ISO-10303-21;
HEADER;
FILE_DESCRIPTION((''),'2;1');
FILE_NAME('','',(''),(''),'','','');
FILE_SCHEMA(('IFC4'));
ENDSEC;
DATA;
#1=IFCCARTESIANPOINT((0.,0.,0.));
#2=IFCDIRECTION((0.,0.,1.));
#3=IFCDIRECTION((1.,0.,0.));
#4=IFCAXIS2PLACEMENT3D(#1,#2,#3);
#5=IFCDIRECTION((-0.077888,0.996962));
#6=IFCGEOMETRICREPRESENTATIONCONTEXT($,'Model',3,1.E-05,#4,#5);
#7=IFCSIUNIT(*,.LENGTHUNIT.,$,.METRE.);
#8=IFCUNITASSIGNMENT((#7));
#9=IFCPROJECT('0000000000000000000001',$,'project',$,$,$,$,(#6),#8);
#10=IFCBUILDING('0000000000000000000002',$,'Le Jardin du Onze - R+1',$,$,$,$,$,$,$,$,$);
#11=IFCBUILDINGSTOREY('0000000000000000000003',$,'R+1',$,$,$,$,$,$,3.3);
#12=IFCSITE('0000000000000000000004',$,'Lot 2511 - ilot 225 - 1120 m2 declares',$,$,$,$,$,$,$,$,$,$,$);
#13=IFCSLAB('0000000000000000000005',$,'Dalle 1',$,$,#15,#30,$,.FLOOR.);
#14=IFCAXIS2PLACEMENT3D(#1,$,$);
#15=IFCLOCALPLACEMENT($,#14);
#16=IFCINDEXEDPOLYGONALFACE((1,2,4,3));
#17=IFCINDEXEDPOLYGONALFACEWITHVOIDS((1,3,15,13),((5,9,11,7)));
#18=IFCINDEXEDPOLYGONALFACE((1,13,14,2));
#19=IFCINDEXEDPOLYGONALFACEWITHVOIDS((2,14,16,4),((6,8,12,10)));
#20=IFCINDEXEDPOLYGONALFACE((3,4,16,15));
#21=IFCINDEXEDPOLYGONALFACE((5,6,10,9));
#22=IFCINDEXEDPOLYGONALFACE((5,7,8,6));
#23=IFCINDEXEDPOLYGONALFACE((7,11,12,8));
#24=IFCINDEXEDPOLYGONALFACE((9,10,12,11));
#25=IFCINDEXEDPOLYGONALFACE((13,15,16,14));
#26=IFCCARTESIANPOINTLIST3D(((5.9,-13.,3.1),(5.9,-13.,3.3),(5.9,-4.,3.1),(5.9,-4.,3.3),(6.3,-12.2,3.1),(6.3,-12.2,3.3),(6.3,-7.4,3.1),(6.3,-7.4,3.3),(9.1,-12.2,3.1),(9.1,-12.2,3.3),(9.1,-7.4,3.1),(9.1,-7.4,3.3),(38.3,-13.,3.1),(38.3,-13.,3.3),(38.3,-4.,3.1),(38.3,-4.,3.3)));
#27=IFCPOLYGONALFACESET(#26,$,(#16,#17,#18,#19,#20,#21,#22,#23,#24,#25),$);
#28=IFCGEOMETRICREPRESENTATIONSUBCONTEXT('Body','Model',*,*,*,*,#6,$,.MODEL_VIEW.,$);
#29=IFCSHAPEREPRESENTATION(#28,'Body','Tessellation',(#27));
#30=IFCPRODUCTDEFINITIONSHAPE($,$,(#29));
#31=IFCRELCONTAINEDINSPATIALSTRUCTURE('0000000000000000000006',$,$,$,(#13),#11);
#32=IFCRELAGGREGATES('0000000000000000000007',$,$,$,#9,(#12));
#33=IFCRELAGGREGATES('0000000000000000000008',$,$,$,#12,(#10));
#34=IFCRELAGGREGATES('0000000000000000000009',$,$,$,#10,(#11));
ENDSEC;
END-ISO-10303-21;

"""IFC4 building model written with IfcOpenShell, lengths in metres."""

from ifc_helpers import new_model, si_unit, direction, frame, origin_with_axes, place, context, subcontext, project, spatial, polyline, outline, extrude, element, save


model = new_model("IFC4")

# Units and contexts
model_context = context("Model", 3, precision=1e-05, world=origin_with_axes(), true_north=direction((-0.077888, 0.996962)))
body_context = subcontext(model_context, "Body", "Model", "MODEL_VIEW")
ifc_project = project(units=[si_unit("LENGTHUNIT", "METRE")], contexts=[model_context])

# Site, building, storey
site = spatial("IfcSite", under=ifc_project, Name="Lot 2511 - ilot 225 - 1120 m2 declares")
building = spatial("IfcBuilding", under=site, Name="Le Jardin du Onze - R+1")
storey = spatial("IfcBuildingStorey", under=building, Name="R+1", Elevation=3.3)

# Slab, opening
slab_placement = place(None, origin_with_axes())
slab = element("IfcSlab", 1, at=slab_placement, inside=storey, Name="Dalle 1", PredefinedType="FLOOR", context=body_context, shape_type="SweptSolid", body=[
    extrude(outline(polyline([(38.3, -13.0), (38.3, -4.0), (5.9, -4.0), (5.9, -13.0), (38.3, -13.0)])), frame((0.0, 0.0, 3.1)), (0.0, 0.0, 1.0), 0.2),
])
opening_1_placement = place(None, origin_with_axes())
element("IfcOpeningElement", 2, at=opening_1_placement, cuts=slab, context=body_context, shape_type="SweptSolid", body=[
    extrude(outline(polyline([(9.1, -12.2), (9.1, -7.4), (6.3, -7.4), (6.3, -12.2), (9.1, -12.2)])), frame((0.0, 0.0, 3.0)), (0.0, 0.0, 1.0), 0.6),
])

save(model, "model.ifc")
